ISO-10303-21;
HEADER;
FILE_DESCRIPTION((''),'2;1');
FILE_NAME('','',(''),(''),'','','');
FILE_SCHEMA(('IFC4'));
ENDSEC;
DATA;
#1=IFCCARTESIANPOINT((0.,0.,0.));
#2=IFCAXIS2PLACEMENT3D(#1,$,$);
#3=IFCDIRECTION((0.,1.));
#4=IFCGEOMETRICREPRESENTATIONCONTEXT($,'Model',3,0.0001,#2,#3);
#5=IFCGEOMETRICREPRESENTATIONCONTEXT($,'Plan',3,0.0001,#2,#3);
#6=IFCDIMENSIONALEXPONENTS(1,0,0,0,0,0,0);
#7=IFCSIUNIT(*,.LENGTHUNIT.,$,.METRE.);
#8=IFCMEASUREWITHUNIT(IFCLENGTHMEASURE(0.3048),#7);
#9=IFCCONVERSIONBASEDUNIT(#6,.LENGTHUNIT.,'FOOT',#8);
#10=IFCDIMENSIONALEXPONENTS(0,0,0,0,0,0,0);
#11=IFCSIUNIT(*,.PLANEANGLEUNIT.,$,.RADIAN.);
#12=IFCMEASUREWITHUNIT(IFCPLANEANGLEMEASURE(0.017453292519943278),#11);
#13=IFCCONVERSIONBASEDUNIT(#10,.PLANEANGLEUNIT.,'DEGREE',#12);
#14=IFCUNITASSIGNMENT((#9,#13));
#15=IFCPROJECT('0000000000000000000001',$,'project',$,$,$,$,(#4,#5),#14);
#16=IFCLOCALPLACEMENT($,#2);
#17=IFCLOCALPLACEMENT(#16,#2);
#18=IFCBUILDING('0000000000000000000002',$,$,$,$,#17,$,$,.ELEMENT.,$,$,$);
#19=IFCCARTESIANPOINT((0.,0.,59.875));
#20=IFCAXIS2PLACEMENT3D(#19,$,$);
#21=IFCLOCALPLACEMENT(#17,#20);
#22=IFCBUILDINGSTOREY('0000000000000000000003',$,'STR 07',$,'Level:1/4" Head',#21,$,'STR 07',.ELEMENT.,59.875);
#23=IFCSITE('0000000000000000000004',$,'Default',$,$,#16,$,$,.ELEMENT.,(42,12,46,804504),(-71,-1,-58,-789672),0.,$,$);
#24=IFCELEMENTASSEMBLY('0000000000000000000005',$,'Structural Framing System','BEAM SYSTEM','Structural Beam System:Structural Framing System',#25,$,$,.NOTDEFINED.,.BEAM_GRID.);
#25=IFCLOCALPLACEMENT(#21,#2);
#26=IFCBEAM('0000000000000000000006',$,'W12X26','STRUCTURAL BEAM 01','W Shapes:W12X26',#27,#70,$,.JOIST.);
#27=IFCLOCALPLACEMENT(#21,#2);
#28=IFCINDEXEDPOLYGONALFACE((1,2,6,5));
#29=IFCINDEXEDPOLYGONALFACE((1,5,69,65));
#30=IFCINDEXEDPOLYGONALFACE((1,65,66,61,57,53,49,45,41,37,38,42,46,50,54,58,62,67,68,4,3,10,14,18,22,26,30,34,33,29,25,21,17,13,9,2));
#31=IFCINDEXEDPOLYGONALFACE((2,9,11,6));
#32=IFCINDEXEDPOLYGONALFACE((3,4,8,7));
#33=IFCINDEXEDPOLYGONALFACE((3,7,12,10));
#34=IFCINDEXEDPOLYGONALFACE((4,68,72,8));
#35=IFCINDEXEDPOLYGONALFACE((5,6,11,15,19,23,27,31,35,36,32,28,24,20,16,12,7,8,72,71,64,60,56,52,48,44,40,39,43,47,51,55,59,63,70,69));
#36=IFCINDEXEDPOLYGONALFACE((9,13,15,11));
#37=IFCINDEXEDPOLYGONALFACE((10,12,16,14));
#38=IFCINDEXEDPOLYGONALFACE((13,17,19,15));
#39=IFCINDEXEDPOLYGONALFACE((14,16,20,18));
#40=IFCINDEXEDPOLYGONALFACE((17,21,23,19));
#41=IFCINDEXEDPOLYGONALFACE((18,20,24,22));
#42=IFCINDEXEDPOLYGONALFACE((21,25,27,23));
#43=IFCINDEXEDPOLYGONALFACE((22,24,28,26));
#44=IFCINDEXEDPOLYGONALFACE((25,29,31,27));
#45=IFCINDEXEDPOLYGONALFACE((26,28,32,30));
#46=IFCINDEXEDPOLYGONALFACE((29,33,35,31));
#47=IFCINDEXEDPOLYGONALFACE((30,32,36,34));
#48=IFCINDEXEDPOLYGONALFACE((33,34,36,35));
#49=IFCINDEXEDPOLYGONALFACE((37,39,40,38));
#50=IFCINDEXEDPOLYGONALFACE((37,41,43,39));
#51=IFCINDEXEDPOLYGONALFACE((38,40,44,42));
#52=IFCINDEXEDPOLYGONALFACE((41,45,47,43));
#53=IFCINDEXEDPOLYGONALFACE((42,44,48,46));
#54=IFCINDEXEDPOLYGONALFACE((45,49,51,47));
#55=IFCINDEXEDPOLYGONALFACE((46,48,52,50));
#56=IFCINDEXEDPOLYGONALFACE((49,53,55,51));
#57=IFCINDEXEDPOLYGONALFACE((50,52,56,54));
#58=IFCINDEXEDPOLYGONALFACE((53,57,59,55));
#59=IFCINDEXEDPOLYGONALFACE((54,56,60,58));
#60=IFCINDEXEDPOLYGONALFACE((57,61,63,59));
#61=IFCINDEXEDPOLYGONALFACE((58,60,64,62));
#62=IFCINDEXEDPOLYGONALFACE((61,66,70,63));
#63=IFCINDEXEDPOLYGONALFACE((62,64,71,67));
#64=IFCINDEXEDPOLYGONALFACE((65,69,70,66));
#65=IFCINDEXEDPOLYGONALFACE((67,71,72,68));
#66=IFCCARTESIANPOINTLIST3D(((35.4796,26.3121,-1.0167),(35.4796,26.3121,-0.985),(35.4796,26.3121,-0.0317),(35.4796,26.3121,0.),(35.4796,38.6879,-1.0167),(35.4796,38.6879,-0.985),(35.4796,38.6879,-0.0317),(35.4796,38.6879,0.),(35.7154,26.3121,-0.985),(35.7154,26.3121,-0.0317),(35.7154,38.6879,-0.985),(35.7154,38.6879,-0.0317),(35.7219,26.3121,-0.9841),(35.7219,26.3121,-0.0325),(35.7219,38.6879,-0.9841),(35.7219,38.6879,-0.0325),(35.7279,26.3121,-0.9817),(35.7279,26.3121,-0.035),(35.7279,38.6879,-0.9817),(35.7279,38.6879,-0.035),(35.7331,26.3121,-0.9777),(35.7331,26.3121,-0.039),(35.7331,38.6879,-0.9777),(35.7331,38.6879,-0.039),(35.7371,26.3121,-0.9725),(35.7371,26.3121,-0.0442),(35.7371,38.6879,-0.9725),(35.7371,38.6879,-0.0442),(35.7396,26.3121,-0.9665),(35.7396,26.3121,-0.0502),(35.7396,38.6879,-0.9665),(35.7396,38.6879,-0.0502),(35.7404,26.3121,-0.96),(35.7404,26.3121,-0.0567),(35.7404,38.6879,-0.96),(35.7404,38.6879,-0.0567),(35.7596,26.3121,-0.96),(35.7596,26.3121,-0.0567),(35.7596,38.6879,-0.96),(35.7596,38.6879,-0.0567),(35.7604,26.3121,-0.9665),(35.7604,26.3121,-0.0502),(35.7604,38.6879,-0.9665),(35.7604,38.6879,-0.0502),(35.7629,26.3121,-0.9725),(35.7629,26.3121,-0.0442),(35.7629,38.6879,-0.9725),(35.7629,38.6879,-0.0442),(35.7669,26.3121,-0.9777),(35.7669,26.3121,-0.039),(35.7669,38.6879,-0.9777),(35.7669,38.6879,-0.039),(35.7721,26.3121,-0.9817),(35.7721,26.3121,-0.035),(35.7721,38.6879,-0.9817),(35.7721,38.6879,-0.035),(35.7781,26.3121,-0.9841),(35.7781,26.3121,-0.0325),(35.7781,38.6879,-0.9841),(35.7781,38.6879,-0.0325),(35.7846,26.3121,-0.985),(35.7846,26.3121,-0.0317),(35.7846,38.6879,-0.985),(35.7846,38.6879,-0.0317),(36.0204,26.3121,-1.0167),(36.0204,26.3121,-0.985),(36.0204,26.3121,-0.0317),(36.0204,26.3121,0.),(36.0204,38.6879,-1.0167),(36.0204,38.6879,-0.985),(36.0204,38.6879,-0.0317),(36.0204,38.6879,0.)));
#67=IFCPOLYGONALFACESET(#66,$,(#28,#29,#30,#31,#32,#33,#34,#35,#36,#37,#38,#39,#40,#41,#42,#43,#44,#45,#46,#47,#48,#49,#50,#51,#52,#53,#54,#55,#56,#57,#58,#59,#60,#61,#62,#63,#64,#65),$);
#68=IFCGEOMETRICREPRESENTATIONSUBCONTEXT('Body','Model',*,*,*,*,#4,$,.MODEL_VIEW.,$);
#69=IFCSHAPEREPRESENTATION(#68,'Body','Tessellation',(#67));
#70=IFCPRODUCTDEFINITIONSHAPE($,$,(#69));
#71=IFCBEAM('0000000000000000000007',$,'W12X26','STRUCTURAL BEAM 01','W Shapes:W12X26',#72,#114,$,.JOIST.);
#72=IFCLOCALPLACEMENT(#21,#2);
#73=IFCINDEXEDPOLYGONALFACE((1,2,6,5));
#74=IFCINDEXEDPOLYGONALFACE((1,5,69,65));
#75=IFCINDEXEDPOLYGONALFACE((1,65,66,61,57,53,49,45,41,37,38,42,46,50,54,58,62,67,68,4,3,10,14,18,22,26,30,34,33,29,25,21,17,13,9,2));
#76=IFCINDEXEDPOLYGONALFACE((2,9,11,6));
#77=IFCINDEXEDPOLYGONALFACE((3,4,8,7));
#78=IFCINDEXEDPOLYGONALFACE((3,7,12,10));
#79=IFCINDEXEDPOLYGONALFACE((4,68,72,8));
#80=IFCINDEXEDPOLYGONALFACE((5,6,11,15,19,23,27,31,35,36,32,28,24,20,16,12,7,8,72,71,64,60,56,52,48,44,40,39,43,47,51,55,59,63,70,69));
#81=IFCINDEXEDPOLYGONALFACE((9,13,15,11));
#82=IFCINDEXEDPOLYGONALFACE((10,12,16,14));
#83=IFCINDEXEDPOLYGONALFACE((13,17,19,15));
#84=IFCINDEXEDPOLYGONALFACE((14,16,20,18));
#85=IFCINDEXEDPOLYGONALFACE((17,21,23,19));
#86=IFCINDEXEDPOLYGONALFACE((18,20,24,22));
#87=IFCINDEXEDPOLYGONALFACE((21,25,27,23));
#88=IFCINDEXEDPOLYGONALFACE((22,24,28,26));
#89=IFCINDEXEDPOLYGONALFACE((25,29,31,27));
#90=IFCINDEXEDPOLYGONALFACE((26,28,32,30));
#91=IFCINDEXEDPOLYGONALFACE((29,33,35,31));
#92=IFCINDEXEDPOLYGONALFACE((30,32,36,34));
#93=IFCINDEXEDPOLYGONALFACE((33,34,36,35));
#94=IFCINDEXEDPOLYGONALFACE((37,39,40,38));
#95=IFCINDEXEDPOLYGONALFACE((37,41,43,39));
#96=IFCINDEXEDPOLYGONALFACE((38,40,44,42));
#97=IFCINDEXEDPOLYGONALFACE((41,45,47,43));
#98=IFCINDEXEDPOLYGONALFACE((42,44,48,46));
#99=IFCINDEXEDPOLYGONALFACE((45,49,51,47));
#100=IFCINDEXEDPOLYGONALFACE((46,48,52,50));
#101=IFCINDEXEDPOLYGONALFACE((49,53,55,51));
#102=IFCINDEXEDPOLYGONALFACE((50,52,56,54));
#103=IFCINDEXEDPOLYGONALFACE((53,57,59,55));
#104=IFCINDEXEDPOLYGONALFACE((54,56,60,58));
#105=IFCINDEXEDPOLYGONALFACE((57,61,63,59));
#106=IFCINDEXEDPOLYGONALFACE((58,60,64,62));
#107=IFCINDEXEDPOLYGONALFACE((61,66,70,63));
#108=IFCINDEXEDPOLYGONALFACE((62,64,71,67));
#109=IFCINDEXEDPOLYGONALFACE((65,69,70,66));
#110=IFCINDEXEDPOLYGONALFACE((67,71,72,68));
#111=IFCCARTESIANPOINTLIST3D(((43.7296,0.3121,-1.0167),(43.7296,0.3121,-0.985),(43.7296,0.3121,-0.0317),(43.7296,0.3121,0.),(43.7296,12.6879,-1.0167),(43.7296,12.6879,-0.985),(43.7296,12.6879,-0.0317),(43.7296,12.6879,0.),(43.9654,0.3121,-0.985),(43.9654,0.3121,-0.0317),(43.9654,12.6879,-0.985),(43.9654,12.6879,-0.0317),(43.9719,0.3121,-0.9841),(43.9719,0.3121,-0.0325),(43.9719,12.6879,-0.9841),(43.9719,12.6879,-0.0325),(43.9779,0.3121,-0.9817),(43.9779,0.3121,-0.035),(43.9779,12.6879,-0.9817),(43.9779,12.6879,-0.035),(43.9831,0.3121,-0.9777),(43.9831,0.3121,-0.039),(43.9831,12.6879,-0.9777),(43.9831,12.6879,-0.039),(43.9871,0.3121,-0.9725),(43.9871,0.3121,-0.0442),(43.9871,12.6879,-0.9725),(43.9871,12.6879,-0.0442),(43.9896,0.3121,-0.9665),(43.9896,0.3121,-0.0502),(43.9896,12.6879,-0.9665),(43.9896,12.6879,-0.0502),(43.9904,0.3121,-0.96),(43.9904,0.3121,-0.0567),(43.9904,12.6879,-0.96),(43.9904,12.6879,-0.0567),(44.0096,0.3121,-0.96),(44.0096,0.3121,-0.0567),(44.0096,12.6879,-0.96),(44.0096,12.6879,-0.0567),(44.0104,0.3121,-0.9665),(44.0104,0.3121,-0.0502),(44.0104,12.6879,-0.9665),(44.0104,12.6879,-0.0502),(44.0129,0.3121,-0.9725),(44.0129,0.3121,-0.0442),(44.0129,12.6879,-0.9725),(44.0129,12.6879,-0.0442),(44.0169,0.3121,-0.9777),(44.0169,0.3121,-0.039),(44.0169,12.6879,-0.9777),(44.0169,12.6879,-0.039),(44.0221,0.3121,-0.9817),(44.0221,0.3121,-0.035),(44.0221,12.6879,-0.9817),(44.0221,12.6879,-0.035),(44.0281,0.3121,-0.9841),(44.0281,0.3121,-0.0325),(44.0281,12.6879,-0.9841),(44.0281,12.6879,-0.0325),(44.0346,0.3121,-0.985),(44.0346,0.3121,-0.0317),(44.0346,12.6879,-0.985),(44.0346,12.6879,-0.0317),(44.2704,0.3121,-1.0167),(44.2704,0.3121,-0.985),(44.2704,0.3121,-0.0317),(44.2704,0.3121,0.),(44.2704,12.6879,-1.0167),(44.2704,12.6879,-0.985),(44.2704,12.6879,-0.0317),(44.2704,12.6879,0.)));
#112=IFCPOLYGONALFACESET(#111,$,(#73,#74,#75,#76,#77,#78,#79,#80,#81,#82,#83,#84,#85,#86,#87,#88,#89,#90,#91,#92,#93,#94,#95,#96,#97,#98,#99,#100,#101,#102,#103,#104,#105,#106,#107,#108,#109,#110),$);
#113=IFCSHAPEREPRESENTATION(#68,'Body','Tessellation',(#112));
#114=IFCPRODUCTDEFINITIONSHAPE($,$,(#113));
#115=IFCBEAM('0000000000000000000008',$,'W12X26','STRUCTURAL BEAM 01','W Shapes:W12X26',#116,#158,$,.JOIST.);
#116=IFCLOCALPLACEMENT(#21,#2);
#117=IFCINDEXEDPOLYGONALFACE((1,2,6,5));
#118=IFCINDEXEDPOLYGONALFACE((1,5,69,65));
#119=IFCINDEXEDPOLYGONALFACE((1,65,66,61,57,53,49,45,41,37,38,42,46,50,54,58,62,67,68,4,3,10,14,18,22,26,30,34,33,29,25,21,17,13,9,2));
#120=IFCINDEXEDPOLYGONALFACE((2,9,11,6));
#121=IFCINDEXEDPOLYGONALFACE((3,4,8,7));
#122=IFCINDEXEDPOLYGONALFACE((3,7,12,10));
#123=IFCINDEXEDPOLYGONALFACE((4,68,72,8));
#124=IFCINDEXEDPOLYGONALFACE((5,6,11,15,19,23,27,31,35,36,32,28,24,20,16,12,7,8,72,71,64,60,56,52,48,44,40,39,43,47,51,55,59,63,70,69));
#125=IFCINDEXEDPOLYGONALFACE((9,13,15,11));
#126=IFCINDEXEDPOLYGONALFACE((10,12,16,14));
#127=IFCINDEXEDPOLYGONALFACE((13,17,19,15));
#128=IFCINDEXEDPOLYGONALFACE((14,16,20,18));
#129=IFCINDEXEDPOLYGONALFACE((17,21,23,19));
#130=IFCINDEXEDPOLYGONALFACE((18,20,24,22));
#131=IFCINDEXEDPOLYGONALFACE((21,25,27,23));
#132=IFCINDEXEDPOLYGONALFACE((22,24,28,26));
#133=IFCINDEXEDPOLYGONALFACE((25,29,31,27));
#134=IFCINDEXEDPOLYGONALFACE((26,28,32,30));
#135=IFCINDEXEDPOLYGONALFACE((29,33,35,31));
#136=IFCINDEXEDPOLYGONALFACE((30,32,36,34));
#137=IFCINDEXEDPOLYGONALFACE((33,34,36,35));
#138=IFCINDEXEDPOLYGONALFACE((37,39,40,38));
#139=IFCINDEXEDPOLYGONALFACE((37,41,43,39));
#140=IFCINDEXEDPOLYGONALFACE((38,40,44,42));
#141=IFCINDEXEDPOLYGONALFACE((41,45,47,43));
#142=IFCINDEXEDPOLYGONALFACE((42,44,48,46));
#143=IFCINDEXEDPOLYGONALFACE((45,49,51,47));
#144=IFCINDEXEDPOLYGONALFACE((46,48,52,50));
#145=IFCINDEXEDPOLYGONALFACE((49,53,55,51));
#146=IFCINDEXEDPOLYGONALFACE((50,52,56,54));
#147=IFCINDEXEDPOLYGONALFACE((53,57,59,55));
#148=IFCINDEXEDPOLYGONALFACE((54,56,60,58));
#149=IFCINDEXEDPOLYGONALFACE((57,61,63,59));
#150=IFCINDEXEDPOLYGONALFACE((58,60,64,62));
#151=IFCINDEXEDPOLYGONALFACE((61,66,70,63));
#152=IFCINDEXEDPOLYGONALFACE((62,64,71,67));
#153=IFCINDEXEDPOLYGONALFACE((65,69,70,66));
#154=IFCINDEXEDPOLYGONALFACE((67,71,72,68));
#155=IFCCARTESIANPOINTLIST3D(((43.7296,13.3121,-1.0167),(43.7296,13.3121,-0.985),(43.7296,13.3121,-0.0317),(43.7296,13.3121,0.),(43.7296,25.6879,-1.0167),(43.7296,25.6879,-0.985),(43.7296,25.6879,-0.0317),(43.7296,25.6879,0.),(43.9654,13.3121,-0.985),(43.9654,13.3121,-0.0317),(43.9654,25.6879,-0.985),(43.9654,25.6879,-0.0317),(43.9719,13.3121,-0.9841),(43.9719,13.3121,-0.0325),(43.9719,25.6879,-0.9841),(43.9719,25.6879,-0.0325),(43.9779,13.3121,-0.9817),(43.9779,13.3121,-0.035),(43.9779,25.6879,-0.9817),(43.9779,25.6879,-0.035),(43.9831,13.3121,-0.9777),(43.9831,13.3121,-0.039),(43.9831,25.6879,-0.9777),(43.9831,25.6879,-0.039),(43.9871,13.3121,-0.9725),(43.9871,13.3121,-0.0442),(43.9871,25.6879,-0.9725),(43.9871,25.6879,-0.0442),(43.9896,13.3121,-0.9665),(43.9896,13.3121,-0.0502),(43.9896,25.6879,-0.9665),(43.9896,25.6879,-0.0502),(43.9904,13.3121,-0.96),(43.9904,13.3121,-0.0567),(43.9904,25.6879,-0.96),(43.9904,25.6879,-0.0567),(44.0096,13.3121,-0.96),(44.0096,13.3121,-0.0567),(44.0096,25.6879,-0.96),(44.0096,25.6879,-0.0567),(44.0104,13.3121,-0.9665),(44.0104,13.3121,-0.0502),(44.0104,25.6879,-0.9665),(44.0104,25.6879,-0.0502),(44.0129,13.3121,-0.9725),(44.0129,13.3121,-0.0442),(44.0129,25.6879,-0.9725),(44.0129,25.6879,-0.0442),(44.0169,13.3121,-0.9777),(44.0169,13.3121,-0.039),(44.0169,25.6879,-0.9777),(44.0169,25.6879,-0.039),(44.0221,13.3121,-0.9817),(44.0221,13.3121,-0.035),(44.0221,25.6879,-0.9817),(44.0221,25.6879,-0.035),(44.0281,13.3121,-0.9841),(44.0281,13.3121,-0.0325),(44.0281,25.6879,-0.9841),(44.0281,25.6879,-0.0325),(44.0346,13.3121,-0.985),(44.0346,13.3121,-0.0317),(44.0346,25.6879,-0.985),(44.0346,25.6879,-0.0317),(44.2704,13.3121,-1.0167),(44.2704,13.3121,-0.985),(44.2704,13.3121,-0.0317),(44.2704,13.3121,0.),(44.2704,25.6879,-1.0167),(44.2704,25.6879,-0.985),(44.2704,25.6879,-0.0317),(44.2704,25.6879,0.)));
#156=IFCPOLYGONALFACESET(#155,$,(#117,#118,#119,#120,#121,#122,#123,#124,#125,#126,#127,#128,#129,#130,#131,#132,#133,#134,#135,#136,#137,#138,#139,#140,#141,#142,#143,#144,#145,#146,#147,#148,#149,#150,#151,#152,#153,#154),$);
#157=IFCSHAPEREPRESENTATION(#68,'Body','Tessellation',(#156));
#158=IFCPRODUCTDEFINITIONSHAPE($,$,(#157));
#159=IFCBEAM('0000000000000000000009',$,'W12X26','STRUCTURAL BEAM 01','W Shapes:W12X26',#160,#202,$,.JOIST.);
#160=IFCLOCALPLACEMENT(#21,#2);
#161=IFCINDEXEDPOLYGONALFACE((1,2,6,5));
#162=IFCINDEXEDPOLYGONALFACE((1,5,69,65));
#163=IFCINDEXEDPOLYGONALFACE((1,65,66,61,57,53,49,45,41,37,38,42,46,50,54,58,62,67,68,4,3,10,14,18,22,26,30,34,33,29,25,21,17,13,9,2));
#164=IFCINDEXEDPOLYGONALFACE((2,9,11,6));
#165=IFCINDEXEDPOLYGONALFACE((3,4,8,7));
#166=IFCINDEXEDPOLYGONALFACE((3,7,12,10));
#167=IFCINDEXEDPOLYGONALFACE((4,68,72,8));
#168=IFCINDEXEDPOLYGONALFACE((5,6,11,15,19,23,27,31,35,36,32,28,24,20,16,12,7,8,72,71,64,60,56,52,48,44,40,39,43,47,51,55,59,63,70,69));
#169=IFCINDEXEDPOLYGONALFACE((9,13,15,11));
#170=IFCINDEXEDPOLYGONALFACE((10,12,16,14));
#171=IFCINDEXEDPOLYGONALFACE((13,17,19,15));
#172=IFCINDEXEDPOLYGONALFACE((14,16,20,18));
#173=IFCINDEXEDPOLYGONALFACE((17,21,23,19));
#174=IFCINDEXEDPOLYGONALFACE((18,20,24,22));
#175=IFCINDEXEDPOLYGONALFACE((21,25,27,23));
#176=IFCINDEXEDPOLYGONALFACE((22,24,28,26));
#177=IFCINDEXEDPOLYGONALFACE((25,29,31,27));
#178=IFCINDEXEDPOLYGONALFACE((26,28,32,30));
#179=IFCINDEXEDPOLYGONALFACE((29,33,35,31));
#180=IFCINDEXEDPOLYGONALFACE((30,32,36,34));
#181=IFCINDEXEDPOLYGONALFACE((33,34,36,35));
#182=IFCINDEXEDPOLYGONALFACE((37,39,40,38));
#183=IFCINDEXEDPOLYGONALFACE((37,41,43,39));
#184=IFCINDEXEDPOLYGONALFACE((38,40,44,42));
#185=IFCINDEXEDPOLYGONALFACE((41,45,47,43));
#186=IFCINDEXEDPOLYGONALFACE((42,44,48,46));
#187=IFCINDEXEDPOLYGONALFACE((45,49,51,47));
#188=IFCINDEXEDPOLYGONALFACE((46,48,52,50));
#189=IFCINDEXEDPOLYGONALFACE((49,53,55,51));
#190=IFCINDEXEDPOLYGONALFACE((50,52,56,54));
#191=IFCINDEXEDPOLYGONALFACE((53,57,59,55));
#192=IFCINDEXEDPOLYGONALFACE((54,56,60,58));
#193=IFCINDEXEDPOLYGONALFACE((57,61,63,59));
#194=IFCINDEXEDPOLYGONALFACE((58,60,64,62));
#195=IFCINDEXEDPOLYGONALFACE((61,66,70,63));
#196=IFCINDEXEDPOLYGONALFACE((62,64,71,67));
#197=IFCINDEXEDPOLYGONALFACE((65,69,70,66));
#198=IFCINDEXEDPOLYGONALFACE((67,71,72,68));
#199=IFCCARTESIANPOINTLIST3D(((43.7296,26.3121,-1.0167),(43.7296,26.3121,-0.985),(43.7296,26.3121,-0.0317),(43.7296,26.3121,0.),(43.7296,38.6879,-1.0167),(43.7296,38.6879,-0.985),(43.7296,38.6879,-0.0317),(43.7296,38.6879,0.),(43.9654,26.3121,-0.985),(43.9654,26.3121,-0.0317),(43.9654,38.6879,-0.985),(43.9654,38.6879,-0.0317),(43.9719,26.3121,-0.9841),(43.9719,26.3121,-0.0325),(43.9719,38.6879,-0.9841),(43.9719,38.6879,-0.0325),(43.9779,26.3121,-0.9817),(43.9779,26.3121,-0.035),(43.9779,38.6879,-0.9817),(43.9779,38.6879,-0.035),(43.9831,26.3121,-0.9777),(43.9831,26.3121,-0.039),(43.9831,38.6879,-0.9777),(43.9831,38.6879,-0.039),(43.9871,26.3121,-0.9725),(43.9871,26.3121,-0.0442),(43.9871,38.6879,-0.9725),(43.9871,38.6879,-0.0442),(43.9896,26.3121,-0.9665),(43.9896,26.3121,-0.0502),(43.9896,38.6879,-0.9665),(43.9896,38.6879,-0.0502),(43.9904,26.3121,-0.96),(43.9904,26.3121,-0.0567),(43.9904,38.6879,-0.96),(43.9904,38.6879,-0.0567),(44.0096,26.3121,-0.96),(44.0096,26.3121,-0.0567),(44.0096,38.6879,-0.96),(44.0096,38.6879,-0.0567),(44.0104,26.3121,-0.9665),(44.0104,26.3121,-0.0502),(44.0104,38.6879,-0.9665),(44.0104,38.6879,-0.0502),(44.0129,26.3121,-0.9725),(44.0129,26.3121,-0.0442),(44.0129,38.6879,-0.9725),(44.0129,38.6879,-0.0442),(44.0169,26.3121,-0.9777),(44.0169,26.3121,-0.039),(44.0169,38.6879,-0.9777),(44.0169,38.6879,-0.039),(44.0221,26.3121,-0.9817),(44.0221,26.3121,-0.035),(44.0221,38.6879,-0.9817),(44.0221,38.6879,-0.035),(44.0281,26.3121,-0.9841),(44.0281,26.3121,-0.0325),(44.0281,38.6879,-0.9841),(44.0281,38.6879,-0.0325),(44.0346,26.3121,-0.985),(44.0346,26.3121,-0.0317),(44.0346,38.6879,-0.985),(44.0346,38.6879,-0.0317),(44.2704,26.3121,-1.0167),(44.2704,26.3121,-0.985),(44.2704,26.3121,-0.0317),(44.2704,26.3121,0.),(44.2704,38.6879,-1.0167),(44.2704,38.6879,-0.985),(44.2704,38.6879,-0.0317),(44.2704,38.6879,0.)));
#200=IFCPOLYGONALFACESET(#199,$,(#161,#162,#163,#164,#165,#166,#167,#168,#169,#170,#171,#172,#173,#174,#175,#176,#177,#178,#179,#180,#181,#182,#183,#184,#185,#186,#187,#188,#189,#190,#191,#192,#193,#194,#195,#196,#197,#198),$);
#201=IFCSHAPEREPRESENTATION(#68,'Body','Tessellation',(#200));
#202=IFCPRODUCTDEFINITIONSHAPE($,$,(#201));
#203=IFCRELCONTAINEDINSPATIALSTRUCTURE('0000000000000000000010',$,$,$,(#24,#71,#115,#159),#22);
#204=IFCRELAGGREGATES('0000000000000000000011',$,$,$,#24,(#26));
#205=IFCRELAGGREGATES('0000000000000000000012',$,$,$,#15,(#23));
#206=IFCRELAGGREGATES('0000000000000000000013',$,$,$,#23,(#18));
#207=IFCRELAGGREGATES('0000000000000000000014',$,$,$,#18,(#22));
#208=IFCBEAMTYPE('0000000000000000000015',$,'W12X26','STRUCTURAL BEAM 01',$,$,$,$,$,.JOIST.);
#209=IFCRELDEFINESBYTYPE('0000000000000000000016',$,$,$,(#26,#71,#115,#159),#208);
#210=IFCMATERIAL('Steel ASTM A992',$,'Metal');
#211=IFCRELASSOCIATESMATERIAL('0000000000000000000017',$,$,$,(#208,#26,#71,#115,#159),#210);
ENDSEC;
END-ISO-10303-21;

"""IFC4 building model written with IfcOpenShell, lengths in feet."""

from ifc_helpers import new_model, entity, si_unit, converted_unit, direction, frame, origin, place, context, subcontext, project, spatial, line, arc, indexed_curve, outline, extrude, source, transform, mapped, material, type_object, type_shapes, element, aggregate, save


model = new_model("IFC4")

# Units and contexts
model_context = context("Model", 3, precision=0.0001, world=origin(), true_north=direction((0.0, 1.0)))
plan_context = context("Plan", 3, precision=0.0001, world=origin(), true_north=direction((0.0, 1.0)))
body_context = subcontext(model_context, "Body", "Model", "MODEL_VIEW")
ifc_project = project(units=[converted_unit("LENGTHUNIT", "FOOT", entity("IfcLengthMeasure", 0.3048), si_unit("LENGTHUNIT", "METRE"), dimensions=[1, 0, 0, 0, 0, 0, 0]), converted_unit("PLANEANGLEUNIT", "DEGREE", entity("IfcPlaneAngleMeasure", 0.017453292519943278), si_unit("PLANEANGLEUNIT", "RADIAN"), dimensions=[0, 0, 0, 0, 0, 0, 0])], contexts=[model_context, plan_context])

# Site, building, storey
site_placement = place(None, origin())
site = spatial("IfcSite", under=ifc_project, at=site_placement, Name="Default", CompositionType="ELEMENT", RefLatitude=(42, 12, 46, 804504), RefLongitude=(-71, -1, -58, -789672), RefElevation=0.0)
building_placement = place(site_placement, origin())
building = spatial("IfcBuilding", under=site, at=building_placement, CompositionType="ELEMENT")
storey_placement = place(building_placement, frame((0.0, 0.0, 59.875)))
storey = spatial("IfcBuildingStorey", under=building, at=storey_placement, Name="STR 07", ObjectType="Level:1/4\" Head", LongName="STR 07", CompositionType="ELEMENT", Elevation=59.875)

# Shared definitions
ifc_material = material(Name="Steel ASTM A992", Category="Metal")

# Element assembly, beam
assembly_placement = place(storey_placement, origin())
assembly = element("IfcElementAssembly", 1, at=assembly_placement, inside=storey, Name="Structural Framing System", Description="BEAM SYSTEM", ObjectType="Structural Beam System:Structural Framing System", AssemblyPlace="NOTDEFINED", PredefinedType="BEAM_GRID")
beam_type_1 = type_object("IfcBeamType", Name="W12X26", Description="STRUCTURAL BEAM 01", PredefinedType="JOIST", material=ifc_material)
shared_shape_1 = source(origin(), body_context, "Body", "SweptSolid", [
    extrude(outline(indexed_curve([(-0.2704, -0.4767), (-0.2704, -0.5083), (0.2704, -0.5083), (0.2704, -0.4767), (0.0346, -0.4767), (0.0169, -0.4693), (0.0096, -0.4517), (0.0096, 0.4517), (0.0169, 0.4693), (0.0346, 0.4767), (0.2704, 0.4767), (0.2704, 0.5083), (-0.2704, 0.5083), (-0.2704, 0.4767), (-0.0346, 0.4767), (-0.0169, 0.4693), (-0.0096, 0.4517), (-0.0096, -0.4517), (-0.0169, -0.4693), (-0.0346, -0.4767)], segments=[line(1, 2, 3, 4, 5), arc(5, 6, 7), line(7, 8), arc(8, 9, 10), line(10, 11, 12, 13, 14, 15), arc(15, 16, 17), line(17, 18), arc(18, 19, 20), line(20, 1)], self_intersect=False)), frame((-6.1879, 0.0, 0.0), z_axis=(-1.0, 0.0, 0.0), x_axis=(0.0, -1.0, 0.0)), (0.0, 0.0, -1.0), 12.3758),
])
type_shapes(beam_type_1, [shared_shape_1])
beam_1_placement = place(assembly_placement, frame((35.75, 32.5, -0.5083), z_axis=(0.0, 0.0, 1.0), x_axis=(0.0, 1.0, 0.0)))
beam_1 = element("IfcBeam", 2, at=beam_1_placement, type_object=beam_type_1, material=ifc_material, Name="W12X26", Description="STRUCTURAL BEAM 01", ObjectType="W Shapes:W12X26", PredefinedType="JOIST", context=body_context, shape_type="MappedRepresentation", body=[
    mapped(shared_shape_1, transform((0.0, 0.0, 0.0), scale=1.0)),
])
aggregate(assembly, [beam_1])

# Beams
for number, where, z_axis, x_axis, name in (
    (3, (44.0, 6.5, -0.5083), (0.0, 0.0, 1.0), (0.0, 1.0, 0.0), "W12X26"),
    (4, (44.0, 19.5, -0.5083), (0.0, 0.0, 1.0), (0.0, 1.0, 0.0), "W12X26"),
    (5, (44.0, 32.5, -0.5083), (0.0, 0.0, 1.0), (0.0, 1.0, 0.0), "W12X26"),
):
    element("IfcBeam", number, at=place(storey_placement, frame(where, z_axis=z_axis, x_axis=x_axis)), inside=storey, type_object=beam_type_1, material=ifc_material, Name=name, Description="STRUCTURAL BEAM 01", ObjectType="W Shapes:W12X26", PredefinedType="JOIST", context=body_context, shape_type="MappedRepresentation", body=[
        mapped(shared_shape_1, transform((0.0, 0.0, 0.0), scale=1.0)),
    ])

save(model, "model.ifc")
